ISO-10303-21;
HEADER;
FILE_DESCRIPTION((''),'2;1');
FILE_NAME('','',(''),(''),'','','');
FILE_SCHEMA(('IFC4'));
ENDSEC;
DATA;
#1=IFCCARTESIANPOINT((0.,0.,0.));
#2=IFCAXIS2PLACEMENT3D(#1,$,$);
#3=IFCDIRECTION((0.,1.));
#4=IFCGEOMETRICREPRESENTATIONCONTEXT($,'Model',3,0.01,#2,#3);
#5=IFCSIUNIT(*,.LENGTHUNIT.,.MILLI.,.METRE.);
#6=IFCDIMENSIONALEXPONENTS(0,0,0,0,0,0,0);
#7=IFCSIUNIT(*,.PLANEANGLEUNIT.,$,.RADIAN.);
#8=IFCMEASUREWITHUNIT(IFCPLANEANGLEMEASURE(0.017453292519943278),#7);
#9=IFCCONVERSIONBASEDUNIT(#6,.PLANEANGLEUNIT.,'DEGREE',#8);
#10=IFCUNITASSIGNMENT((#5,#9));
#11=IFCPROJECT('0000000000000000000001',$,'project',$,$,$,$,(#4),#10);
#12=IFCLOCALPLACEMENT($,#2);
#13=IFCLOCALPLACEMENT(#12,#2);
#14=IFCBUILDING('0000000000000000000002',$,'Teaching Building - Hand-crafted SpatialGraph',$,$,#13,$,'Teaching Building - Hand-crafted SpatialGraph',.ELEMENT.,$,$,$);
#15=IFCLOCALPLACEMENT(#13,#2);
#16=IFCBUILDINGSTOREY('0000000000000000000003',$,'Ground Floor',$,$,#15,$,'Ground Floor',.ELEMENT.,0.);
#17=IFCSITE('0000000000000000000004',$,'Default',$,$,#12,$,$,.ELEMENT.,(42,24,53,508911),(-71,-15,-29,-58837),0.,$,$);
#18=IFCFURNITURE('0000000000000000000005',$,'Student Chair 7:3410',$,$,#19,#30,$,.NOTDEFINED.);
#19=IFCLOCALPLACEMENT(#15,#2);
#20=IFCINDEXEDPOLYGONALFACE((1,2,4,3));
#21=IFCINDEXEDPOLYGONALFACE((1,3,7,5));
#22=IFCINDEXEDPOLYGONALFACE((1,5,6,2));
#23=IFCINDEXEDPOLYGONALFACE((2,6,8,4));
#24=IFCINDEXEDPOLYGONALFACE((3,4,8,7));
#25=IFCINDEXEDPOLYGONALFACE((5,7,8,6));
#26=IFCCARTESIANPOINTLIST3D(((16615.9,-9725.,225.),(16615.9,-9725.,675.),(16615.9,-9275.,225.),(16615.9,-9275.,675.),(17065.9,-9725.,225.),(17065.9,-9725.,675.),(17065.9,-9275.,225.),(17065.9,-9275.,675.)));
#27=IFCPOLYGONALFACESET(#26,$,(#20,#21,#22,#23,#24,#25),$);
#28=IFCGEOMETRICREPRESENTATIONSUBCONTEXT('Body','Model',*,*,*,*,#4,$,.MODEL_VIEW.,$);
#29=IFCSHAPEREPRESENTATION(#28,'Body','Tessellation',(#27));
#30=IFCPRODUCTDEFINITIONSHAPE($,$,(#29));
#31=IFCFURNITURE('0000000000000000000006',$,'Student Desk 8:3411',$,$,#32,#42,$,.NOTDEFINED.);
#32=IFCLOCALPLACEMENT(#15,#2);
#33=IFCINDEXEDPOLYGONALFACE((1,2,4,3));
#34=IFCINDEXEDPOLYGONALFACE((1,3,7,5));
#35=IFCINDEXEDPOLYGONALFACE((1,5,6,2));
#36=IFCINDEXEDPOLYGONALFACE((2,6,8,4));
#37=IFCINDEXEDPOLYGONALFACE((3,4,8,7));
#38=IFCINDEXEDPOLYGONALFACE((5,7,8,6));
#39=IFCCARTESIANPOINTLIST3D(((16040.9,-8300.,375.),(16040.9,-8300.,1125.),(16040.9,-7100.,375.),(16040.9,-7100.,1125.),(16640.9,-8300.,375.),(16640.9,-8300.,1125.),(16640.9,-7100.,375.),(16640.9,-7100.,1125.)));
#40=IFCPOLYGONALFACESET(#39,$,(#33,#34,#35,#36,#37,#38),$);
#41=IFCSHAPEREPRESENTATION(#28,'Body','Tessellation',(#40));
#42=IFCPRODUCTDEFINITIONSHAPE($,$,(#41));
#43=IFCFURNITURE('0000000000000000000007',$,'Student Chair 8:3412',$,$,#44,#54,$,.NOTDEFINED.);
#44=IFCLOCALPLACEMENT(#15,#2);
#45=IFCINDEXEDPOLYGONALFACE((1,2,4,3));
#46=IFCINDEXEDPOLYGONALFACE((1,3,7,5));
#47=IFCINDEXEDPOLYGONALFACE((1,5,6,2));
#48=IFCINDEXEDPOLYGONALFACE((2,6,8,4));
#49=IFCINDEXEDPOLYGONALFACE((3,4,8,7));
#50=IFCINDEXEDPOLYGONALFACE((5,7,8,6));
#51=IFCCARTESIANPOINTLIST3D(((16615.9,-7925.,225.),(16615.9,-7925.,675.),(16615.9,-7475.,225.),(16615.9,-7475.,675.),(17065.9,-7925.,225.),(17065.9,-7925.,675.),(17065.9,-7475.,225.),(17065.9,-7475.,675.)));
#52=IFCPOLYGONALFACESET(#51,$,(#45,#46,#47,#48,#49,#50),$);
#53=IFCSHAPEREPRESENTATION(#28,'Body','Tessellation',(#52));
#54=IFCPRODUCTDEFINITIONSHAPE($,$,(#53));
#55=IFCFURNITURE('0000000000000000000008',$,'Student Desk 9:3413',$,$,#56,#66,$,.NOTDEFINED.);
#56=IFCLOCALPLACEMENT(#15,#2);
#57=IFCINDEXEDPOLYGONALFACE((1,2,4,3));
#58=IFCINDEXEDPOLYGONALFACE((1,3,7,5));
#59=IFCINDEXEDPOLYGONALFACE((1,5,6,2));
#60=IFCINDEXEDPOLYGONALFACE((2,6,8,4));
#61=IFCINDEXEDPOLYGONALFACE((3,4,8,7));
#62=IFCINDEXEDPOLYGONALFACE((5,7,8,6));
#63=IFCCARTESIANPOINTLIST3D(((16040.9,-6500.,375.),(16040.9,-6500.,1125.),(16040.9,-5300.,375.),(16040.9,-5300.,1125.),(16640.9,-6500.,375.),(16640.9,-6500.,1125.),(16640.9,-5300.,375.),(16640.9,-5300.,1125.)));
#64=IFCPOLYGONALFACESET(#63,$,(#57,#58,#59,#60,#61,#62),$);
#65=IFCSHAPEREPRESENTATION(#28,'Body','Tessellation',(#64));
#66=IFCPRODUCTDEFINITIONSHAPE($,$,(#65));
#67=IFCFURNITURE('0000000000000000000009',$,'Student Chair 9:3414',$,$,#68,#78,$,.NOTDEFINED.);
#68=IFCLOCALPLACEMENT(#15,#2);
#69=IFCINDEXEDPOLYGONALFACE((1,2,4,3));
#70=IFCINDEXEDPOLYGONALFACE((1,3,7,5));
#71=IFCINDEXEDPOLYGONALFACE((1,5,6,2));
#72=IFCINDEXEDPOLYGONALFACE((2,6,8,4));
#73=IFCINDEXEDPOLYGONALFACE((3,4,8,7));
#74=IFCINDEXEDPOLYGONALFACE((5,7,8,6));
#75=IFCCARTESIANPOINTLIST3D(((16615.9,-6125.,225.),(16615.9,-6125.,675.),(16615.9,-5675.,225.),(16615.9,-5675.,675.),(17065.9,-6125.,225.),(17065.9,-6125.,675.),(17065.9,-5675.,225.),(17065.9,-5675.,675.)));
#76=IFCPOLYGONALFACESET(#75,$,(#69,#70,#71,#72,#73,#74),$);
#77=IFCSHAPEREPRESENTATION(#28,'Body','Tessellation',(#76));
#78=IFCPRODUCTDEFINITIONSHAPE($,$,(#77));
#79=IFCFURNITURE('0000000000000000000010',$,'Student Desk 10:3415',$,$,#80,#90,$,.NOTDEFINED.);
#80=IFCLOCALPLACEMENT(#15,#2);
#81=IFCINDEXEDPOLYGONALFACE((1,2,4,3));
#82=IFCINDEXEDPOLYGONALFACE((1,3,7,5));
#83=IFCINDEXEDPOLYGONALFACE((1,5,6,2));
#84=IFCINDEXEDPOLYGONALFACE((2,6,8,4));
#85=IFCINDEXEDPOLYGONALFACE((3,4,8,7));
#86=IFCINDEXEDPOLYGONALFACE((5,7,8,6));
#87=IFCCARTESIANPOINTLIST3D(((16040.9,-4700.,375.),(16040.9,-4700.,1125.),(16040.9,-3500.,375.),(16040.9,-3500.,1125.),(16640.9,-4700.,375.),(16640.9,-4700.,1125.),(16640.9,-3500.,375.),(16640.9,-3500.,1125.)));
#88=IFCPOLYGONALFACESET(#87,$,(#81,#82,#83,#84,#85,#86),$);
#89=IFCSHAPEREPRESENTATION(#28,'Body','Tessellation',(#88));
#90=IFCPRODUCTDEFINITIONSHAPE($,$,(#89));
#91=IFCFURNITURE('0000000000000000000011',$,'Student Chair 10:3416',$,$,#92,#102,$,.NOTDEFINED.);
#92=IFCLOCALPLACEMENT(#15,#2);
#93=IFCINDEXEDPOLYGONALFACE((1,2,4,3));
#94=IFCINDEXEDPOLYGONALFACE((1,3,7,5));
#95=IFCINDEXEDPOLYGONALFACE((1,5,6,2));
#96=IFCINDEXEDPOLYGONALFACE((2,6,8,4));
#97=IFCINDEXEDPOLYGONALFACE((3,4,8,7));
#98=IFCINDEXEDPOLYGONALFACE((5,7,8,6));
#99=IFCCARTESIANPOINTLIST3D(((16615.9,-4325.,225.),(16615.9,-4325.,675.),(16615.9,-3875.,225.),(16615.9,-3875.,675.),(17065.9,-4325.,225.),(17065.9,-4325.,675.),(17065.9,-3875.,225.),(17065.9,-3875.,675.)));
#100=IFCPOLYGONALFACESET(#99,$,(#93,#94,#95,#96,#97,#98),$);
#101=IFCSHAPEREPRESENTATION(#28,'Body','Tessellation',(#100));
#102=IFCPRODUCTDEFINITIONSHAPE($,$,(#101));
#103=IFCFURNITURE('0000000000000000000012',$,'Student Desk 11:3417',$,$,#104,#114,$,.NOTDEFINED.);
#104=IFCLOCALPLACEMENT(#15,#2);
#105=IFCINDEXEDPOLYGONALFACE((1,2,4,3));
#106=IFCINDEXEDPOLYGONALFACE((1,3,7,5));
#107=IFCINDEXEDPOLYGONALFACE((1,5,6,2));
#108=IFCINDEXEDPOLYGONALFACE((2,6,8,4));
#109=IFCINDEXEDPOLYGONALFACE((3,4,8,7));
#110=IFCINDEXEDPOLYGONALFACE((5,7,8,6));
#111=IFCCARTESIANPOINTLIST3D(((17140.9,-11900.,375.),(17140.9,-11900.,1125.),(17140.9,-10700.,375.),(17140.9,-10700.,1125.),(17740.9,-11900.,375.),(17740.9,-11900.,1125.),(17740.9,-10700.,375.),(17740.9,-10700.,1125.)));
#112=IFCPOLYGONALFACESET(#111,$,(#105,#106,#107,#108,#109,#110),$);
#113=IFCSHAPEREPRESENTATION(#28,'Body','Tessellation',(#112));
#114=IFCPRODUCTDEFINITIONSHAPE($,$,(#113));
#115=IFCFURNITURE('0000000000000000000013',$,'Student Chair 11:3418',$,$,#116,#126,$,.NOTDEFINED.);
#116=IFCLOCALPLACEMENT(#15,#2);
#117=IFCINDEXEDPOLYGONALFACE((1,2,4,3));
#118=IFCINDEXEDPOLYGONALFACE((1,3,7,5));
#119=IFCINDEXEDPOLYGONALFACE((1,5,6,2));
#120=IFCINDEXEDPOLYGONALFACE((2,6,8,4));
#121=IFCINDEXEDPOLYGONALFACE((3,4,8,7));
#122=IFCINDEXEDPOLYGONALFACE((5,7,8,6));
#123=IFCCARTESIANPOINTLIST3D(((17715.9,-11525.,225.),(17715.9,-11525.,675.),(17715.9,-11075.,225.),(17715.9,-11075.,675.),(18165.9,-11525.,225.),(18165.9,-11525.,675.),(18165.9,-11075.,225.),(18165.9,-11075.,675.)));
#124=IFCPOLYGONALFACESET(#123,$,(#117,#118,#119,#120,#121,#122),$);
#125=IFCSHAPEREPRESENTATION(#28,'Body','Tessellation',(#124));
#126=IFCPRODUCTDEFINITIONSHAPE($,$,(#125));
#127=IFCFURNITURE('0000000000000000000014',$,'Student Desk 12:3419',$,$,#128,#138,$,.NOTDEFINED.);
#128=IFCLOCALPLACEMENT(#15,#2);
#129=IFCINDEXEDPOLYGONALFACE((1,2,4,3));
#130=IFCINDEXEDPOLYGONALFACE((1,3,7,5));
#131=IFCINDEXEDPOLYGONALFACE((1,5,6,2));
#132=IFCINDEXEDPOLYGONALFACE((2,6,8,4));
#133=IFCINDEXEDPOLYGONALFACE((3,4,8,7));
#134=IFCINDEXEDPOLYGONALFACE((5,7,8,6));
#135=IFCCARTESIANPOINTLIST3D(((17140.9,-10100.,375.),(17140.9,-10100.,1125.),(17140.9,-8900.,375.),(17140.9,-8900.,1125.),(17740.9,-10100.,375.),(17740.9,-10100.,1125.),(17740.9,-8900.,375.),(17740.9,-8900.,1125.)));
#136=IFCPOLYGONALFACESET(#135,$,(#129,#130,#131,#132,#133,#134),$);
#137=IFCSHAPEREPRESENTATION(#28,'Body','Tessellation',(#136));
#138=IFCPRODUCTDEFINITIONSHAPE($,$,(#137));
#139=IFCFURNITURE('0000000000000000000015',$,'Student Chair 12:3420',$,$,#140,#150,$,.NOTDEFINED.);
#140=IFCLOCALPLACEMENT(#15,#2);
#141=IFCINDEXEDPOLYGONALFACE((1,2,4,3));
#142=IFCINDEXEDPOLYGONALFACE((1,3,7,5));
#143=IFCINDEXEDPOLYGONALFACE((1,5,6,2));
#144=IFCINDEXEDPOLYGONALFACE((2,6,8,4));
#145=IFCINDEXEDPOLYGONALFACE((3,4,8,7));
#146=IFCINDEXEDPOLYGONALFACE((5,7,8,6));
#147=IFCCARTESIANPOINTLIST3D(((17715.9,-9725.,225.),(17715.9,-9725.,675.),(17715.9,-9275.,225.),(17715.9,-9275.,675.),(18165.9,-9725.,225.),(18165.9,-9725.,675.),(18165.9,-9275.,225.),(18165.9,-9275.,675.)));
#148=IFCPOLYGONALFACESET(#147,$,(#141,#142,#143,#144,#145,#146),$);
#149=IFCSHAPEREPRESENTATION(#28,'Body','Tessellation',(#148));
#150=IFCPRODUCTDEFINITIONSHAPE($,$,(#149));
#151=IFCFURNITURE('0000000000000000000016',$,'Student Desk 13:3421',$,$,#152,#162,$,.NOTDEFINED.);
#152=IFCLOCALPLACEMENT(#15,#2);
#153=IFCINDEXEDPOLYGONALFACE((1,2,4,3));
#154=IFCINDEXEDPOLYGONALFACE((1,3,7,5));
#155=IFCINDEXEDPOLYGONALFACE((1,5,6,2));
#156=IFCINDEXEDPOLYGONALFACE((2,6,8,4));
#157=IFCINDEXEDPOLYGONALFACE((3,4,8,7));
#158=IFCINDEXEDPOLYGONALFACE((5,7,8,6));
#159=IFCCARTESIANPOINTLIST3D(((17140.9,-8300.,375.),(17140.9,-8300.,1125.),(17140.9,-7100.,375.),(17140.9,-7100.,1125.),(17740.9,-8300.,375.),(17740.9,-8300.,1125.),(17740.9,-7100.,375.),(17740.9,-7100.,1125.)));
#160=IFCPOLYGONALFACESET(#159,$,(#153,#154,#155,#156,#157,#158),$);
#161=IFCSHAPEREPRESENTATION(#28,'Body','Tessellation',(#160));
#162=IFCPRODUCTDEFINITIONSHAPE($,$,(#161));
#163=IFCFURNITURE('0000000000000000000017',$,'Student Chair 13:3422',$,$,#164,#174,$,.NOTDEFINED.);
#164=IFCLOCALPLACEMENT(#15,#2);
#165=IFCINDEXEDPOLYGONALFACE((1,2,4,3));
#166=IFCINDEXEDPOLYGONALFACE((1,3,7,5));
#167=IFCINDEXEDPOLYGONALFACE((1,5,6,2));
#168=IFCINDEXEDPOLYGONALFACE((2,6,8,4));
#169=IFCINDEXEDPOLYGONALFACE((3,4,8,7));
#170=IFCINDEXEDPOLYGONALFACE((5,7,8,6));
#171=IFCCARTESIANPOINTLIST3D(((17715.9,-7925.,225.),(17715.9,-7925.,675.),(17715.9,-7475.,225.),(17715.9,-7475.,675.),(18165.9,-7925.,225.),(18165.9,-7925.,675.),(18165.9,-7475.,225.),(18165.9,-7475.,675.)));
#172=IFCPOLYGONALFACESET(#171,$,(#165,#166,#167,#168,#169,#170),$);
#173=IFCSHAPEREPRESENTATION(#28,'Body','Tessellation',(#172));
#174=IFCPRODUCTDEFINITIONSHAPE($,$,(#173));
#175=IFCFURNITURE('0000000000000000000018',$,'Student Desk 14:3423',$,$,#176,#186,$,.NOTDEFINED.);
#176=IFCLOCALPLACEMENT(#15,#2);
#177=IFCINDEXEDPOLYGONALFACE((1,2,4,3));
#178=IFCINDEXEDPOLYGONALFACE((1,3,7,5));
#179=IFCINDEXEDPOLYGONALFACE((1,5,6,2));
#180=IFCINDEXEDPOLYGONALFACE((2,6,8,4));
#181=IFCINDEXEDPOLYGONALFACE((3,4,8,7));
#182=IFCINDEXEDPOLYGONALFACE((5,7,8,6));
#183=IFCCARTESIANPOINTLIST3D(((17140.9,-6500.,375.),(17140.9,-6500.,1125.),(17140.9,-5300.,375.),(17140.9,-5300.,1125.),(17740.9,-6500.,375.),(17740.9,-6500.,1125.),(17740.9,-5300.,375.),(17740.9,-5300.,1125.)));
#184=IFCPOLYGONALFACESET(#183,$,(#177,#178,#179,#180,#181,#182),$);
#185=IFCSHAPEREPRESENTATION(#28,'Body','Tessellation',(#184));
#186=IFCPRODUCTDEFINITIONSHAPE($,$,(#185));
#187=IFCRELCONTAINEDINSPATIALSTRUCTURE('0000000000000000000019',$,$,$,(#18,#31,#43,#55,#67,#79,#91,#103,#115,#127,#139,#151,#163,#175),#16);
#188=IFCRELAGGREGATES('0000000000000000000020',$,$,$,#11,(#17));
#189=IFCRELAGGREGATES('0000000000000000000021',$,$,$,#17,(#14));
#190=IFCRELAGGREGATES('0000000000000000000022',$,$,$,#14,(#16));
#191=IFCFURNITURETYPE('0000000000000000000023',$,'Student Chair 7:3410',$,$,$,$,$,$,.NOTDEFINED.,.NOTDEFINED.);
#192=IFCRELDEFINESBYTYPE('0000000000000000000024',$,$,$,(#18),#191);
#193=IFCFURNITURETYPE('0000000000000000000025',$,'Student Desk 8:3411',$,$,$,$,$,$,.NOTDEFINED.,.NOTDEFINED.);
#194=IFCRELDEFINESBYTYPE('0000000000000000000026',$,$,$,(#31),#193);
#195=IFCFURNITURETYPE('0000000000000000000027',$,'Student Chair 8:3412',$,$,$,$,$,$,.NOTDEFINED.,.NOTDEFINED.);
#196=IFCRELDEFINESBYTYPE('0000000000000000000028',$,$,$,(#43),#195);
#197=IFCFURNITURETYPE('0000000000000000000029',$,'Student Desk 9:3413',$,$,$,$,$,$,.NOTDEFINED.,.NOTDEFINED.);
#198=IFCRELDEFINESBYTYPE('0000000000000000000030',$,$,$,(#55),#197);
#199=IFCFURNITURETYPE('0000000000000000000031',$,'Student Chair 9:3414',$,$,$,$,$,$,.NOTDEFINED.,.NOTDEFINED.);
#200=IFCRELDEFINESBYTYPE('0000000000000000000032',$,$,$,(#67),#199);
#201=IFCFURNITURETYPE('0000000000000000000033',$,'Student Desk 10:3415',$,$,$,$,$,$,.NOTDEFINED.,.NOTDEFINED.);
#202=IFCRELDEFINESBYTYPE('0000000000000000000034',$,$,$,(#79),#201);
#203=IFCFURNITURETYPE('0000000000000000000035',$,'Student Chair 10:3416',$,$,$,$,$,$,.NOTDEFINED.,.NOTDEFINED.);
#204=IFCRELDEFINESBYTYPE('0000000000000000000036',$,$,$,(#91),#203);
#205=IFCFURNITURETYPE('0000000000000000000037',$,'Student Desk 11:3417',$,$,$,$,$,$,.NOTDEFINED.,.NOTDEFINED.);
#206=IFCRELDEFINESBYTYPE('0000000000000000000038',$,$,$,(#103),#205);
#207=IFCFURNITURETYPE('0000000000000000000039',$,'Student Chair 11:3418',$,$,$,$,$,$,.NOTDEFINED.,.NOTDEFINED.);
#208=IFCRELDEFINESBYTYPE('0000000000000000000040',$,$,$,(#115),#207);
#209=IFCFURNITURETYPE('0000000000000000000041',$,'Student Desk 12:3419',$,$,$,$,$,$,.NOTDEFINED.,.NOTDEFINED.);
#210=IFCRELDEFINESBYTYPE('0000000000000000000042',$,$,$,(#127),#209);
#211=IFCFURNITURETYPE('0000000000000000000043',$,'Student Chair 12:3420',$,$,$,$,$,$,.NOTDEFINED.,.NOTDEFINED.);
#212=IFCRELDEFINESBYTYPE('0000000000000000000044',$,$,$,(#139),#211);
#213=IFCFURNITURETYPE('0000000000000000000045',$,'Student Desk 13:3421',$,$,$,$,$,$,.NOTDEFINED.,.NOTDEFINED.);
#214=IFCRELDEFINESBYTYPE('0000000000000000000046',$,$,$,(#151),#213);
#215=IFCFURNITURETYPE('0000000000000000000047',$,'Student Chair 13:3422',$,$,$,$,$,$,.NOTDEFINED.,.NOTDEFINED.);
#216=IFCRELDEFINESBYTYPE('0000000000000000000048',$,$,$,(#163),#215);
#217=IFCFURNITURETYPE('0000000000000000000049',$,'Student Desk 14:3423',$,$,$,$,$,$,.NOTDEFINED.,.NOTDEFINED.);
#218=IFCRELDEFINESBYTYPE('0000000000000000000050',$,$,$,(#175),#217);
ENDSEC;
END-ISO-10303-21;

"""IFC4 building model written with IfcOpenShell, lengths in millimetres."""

from ifc_helpers import new_model, entity, si_unit, converted_unit, direction, frame, frame_2d, origin, origin_2d_with_axis, place, context, subcontext, project, spatial, rectangle, extrude, type_object, element, save


model = new_model("IFC4")

# Units and contexts
model_context = context("Model", 3, precision=0.01, world=origin(), true_north=direction((0.0, 1.0)))
body_context = subcontext(model_context, "Body", "Model", "MODEL_VIEW")
ifc_project = project(units=[si_unit("LENGTHUNIT", "METRE", prefix="MILLI"), converted_unit("PLANEANGLEUNIT", "DEGREE", entity("IfcPlaneAngleMeasure", 0.017453292519943278), si_unit("PLANEANGLEUNIT", "RADIAN"), dimensions=[0, 0, 0, 0, 0, 0, 0])], contexts=[model_context])

# Site, building, storey
site_placement = place(None, origin())
site = spatial("IfcSite", under=ifc_project, at=site_placement, Name="Default", CompositionType="ELEMENT", RefLatitude=(42, 24, 53, 508911), RefLongitude=(-71, -15, -29, -58837), RefElevation=0.0)
building_placement = place(site_placement, origin())
building = spatial("IfcBuilding", under=site, at=building_placement, Name="Teaching Building - Hand-crafted SpatialGraph", LongName="Teaching Building - Hand-crafted SpatialGraph", CompositionType="ELEMENT")
storey_placement = place(building_placement, origin())
storey = spatial("IfcBuildingStorey", under=building, at=storey_placement, Name="Ground Floor", LongName="Ground Floor", CompositionType="ELEMENT", Elevation=0.0)

# Furniture
furniture_type_1 = type_object("IfcFurnitureType", Name="Student Chair 7:3410", PredefinedType="NOTDEFINED")
furniture_1_placement = place(storey_placement, origin())
element("IfcFurniture", 1, at=furniture_1_placement, inside=storey, type_object=furniture_type_1, Name="Student Chair 7:3410", PredefinedType="NOTDEFINED", context=body_context, shape_type="SweptSolid", body=[
    extrude(rectangle(XDim=450.0, YDim=450.0, at=origin_2d_with_axis()), frame((16840.9, -9500.0, 225.0)), (0.0, 0.0, 1.0), 450.0),
])
furniture_type_2 = type_object("IfcFurnitureType", Name="Student Desk 8:3411", PredefinedType="NOTDEFINED")
furniture_2_placement = place(storey_placement, origin())
element("IfcFurniture", 2, at=furniture_2_placement, inside=storey, type_object=furniture_type_2, Name="Student Desk 8:3411", PredefinedType="NOTDEFINED", context=body_context, shape_type="SweptSolid", body=[
    extrude(rectangle(XDim=1200.0, YDim=600.0, at=origin_2d_with_axis()), frame((16340.9, -7700.0, 375.0), z_axis=(0.0, 0.0, 1.0), x_axis=(0.0, 1.0, 0.0)), (0.0, 0.0, 1.0), 750.0),
])
furniture_type_3 = type_object("IfcFurnitureType", Name="Student Chair 8:3412", PredefinedType="NOTDEFINED")
furniture_3_placement = place(storey_placement, origin())
element("IfcFurniture", 3, at=furniture_3_placement, inside=storey, type_object=furniture_type_3, Name="Student Chair 8:3412", PredefinedType="NOTDEFINED", context=body_context, shape_type="SweptSolid", body=[
    extrude(rectangle(XDim=450.0, YDim=450.0, at=frame_2d((0.0, 0.0), x_axis=(1.0, 0.0))), frame((16840.9, -7700.0, 225.0)), (0.0, 0.0, 1.0), 450.0),
])
furniture_type_4 = type_object("IfcFurnitureType", Name="Student Desk 9:3413", PredefinedType="NOTDEFINED")
furniture_4_placement = place(storey_placement, origin())
element("IfcFurniture", 4, at=furniture_4_placement, inside=storey, type_object=furniture_type_4, Name="Student Desk 9:3413", PredefinedType="NOTDEFINED", context=body_context, shape_type="SweptSolid", body=[
    extrude(rectangle(XDim=1200.0, YDim=600.0, at=origin_2d_with_axis()), frame((16340.9, -5900.0, 375.0), z_axis=(0.0, 0.0, 1.0), x_axis=(0.0, 1.0, 0.0)), (0.0, 0.0, 1.0), 750.0),
])
furniture_type_5 = type_object("IfcFurnitureType", Name="Student Chair 9:3414", PredefinedType="NOTDEFINED")
furniture_5_placement = place(storey_placement, origin())
element("IfcFurniture", 5, at=furniture_5_placement, inside=storey, type_object=furniture_type_5, Name="Student Chair 9:3414", PredefinedType="NOTDEFINED", context=body_context, shape_type="SweptSolid", body=[
    extrude(rectangle(XDim=450.0, YDim=450.0, at=origin_2d_with_axis()), frame((16840.9, -5900.0, 225.0)), (0.0, 0.0, 1.0), 450.0),
])
furniture_type_6 = type_object("IfcFurnitureType", Name="Student Desk 10:3415", PredefinedType="NOTDEFINED")
furniture_6_placement = place(storey_placement, origin())
element("IfcFurniture", 6, at=furniture_6_placement, inside=storey, type_object=furniture_type_6, Name="Student Desk 10:3415", PredefinedType="NOTDEFINED", context=body_context, shape_type="SweptSolid", body=[
    extrude(rectangle(XDim=1200.0, YDim=600.0, at=origin_2d_with_axis()), frame((16340.9, -4100.0, 375.0), z_axis=(0.0, 0.0, 1.0), x_axis=(0.0, 1.0, 0.0)), (0.0, 0.0, 1.0), 750.0),
])
furniture_type_7 = type_object("IfcFurnitureType", Name="Student Chair 10:3416", PredefinedType="NOTDEFINED")
furniture_7_placement = place(storey_placement, origin())
element("IfcFurniture", 7, at=furniture_7_placement, inside=storey, type_object=furniture_type_7, Name="Student Chair 10:3416", PredefinedType="NOTDEFINED", context=body_context, shape_type="SweptSolid", body=[
    extrude(rectangle(XDim=450.0, YDim=450.0, at=origin_2d_with_axis()), frame((16840.9, -4100.0, 225.0)), (0.0, 0.0, 1.0), 450.0),
])
furniture_type_8 = type_object("IfcFurnitureType", Name="Student Desk 11:3417", PredefinedType="NOTDEFINED")
furniture_8_placement = place(storey_placement, origin())
element("IfcFurniture", 8, at=furniture_8_placement, inside=storey, type_object=furniture_type_8, Name="Student Desk 11:3417", PredefinedType="NOTDEFINED", context=body_context, shape_type="SweptSolid", body=[
    extrude(rectangle(XDim=1200.0, YDim=600.0, at=origin_2d_with_axis()), frame((17440.9, -11300.0, 375.0), z_axis=(0.0, 0.0, 1.0), x_axis=(0.0, 1.0, 0.0)), (0.0, 0.0, 1.0), 750.0),
])
furniture_type_9 = type_object("IfcFurnitureType", Name="Student Chair 11:3418", PredefinedType="NOTDEFINED")
furniture_9_placement = place(storey_placement, origin())
element("IfcFurniture", 9, at=furniture_9_placement, inside=storey, type_object=furniture_type_9, Name="Student Chair 11:3418", PredefinedType="NOTDEFINED", context=body_context, shape_type="SweptSolid", body=[
    extrude(rectangle(XDim=450.0, YDim=450.0, at=origin_2d_with_axis()), frame((17940.9, -11300.0, 225.0)), (0.0, 0.0, 1.0), 450.0),
])
furniture_type_10 = type_object("IfcFurnitureType", Name="Student Desk 12:3419", PredefinedType="NOTDEFINED")
furniture_10_placement = place(storey_placement, origin())
element("IfcFurniture", 10, at=furniture_10_placement, inside=storey, type_object=furniture_type_10, Name="Student Desk 12:3419", PredefinedType="NOTDEFINED", context=body_context, shape_type="SweptSolid", body=[
    extrude(rectangle(XDim=1200.0, YDim=600.0, at=origin_2d_with_axis()), frame((17440.9, -9500.0, 375.0), z_axis=(0.0, 0.0, 1.0), x_axis=(0.0, 1.0, 0.0)), (0.0, 0.0, 1.0), 750.0),
])
furniture_type_11 = type_object("IfcFurnitureType", Name="Student Chair 12:3420", PredefinedType="NOTDEFINED")
furniture_11_placement = place(storey_placement, origin())
element("IfcFurniture", 11, at=furniture_11_placement, inside=storey, type_object=furniture_type_11, Name="Student Chair 12:3420", PredefinedType="NOTDEFINED", context=body_context, shape_type="SweptSolid", body=[
    extrude(rectangle(XDim=450.0, YDim=450.0, at=origin_2d_with_axis()), frame((17940.9, -9500.0, 225.0)), (0.0, 0.0, 1.0), 450.0),
])
furniture_type_12 = type_object("IfcFurnitureType", Name="Student Desk 13:3421", PredefinedType="NOTDEFINED")
furniture_12_placement = place(storey_placement, origin())
element("IfcFurniture", 12, at=furniture_12_placement, inside=storey, type_object=furniture_type_12, Name="Student Desk 13:3421", PredefinedType="NOTDEFINED", context=body_context, shape_type="SweptSolid", body=[
    extrude(rectangle(XDim=1200.0, YDim=600.0, at=origin_2d_with_axis()), frame((17440.9, -7700.0, 375.0), z_axis=(0.0, 0.0, 1.0), x_axis=(0.0, 1.0, 0.0)), (0.0, 0.0, 1.0), 750.0),
])
furniture_type_13 = type_object("IfcFurnitureType", Name="Student Chair 13:3422", PredefinedType="NOTDEFINED")
furniture_13_placement = place(storey_placement, origin())
element("IfcFurniture", 13, at=furniture_13_placement, inside=storey, type_object=furniture_type_13, Name="Student Chair 13:3422", PredefinedType="NOTDEFINED", context=body_context, shape_type="SweptSolid", body=[
    extrude(rectangle(XDim=450.0, YDim=450.0, at=frame_2d((0.0, 0.0), x_axis=(1.0, 0.0))), frame((17940.9, -7700.0, 225.0)), (0.0, 0.0, 1.0), 450.0),
])
furniture_type_14 = type_object("IfcFurnitureType", Name="Student Desk 14:3423", PredefinedType="NOTDEFINED")
furniture_14_placement = place(storey_placement, origin())
element("IfcFurniture", 14, at=furniture_14_placement, inside=storey, type_object=furniture_type_14, Name="Student Desk 14:3423", PredefinedType="NOTDEFINED", context=body_context, shape_type="SweptSolid", body=[
    extrude(rectangle(XDim=1200.0, YDim=600.0, at=origin_2d_with_axis()), frame((17440.9, -5900.0, 375.0), z_axis=(0.0, 0.0, 1.0), x_axis=(0.0, 1.0, 0.0)), (0.0, 0.0, 1.0), 750.0),
])

save(model, "model.ifc")
